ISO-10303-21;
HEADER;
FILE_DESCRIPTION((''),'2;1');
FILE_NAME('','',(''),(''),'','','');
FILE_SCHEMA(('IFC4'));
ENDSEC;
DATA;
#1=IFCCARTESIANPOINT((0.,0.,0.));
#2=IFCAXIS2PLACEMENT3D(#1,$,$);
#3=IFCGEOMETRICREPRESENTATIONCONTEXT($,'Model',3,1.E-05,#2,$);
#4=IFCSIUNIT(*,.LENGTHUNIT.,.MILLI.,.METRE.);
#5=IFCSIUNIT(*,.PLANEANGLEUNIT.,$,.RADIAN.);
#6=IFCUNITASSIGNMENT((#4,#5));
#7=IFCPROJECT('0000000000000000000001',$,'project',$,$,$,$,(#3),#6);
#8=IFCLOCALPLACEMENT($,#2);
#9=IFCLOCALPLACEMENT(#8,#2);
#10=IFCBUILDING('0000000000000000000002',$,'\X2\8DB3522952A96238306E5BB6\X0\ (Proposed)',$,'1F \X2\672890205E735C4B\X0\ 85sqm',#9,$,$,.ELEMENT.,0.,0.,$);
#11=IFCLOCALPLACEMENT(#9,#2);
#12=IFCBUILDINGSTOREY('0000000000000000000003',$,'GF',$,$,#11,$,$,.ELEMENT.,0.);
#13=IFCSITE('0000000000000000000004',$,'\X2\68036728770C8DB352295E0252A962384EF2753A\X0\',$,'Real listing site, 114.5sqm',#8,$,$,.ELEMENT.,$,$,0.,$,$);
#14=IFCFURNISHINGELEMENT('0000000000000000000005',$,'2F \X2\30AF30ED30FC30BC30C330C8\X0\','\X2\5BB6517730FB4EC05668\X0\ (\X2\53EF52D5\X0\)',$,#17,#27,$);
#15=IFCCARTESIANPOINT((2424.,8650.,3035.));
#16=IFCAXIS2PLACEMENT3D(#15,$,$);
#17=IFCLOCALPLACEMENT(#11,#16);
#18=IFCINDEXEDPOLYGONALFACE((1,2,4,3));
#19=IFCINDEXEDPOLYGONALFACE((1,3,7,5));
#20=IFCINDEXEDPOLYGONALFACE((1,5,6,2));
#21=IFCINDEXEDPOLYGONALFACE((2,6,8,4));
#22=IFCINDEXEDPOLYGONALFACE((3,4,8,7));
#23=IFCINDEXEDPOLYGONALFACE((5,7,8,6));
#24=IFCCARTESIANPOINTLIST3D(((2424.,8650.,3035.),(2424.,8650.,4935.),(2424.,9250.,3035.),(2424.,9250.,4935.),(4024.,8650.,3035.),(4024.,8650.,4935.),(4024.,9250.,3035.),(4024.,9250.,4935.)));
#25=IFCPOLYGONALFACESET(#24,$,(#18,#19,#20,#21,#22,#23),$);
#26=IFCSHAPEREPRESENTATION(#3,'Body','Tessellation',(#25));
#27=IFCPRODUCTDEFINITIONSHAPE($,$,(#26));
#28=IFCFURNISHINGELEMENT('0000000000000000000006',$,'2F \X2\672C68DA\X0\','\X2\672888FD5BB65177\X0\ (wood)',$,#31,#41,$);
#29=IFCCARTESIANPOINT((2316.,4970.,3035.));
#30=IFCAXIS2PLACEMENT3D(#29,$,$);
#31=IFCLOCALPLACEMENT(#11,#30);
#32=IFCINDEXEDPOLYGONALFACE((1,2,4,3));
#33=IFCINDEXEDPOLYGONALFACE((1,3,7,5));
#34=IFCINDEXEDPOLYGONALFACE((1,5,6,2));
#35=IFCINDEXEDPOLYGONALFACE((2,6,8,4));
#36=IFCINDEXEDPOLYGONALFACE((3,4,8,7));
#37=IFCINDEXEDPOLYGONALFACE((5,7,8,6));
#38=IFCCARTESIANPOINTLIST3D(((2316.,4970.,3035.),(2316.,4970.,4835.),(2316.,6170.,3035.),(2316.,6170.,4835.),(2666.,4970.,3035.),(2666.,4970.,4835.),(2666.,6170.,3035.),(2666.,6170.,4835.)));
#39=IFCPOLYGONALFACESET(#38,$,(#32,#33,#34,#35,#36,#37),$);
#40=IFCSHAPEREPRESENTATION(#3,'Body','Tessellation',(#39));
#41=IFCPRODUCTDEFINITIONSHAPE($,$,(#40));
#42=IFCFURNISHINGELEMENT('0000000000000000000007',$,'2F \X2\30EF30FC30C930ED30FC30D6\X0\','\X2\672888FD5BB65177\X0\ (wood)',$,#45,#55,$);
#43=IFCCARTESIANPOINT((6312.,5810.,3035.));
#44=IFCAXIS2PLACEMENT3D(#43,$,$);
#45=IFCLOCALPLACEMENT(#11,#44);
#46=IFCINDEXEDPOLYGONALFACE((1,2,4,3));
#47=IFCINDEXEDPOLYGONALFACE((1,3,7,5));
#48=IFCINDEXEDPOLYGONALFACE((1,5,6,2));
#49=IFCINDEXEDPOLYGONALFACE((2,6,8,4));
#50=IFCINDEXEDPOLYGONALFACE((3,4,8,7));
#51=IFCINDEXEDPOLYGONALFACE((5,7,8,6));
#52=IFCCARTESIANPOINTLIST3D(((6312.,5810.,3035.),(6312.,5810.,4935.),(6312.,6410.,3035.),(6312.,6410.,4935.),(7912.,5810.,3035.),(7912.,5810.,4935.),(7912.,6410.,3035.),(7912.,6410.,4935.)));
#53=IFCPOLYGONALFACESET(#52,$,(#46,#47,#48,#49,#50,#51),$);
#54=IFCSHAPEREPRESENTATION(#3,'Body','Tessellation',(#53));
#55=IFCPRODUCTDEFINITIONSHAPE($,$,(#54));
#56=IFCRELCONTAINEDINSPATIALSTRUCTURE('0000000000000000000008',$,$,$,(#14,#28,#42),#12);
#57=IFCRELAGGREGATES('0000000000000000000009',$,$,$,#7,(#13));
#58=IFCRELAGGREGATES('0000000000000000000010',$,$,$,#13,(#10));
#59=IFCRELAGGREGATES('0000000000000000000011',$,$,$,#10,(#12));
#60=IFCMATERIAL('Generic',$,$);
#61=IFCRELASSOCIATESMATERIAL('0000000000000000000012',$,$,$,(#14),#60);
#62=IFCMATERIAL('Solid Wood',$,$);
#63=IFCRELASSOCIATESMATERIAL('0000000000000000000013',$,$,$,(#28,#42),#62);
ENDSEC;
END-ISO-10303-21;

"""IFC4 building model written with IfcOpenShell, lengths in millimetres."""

from ifc_helpers import new_model, si_unit, frame, frame_2d, origin, place, context, project, spatial, rectangle, extrude, material, element, save


model = new_model("IFC4")

# Units and contexts
model_context = context("Model", 3, precision=1e-05, world=origin())
ifc_project = project(units=[si_unit("LENGTHUNIT", "METRE", prefix="MILLI"), si_unit("PLANEANGLEUNIT", "RADIAN")], contexts=[model_context])

# Site, building, storey
site_placement = place(None, origin())
site = spatial("IfcSite", under=ifc_project, at=site_placement, Name="栃木県足利市助戸仲町", ObjectType="Real listing site, 114.5sqm", CompositionType="ELEMENT", RefElevation=0.0)
building_placement = place(site_placement, origin())
building = spatial("IfcBuilding", under=site, at=building_placement, Name="足利助戸の家 (Proposed)", ObjectType="1F 木造平屋 85sqm", CompositionType="ELEMENT", ElevationOfRefHeight=0.0, ElevationOfTerrain=0.0)
storey_placement = place(building_placement, origin())
storey = spatial("IfcBuildingStorey", under=building, at=storey_placement, Name="GF", CompositionType="ELEMENT", Elevation=0.0)

# Shared definitions
ifc_material_1 = material(Name="Solid Wood")

# Shared definitions
ifc_material_2 = material(Name="Generic")

# Furnishing elements
furnishing_1_placement = place(storey_placement, frame((2424.0, 8650.0, 3035.0)))
element("IfcFurnishingElement", 1, at=furnishing_1_placement, inside=storey, material=ifc_material_2, Name="2F クローゼット", Description="家具・什器 (可動)", context=model_context, shape_type="SweptSolid", body=[
    extrude(rectangle(XDim=1600.0, YDim=600.0, at=frame_2d((800.0, 300.0))), frame((2424.0, 8650.0, 3035.0)), (0.0, 0.0, 1.0), 1900.0),
])
furnishing_2_placement = place(storey_placement, frame((2316.0, 4970.0, 3035.0)))
element("IfcFurnishingElement", 2, at=furnishing_2_placement, inside=storey, material=ifc_material_1, Name="2F 本棚", Description="木製家具 (wood)", context=model_context, shape_type="SweptSolid", body=[
    extrude(rectangle(XDim=350.0, YDim=1200.0, at=frame_2d((175.0, 600.0))), frame((2316.0, 4970.0, 3035.0)), (0.0, 0.0, 1.0), 1800.0),
])
furnishing_3_placement = place(storey_placement, frame((6312.0, 5810.0, 3035.0)))
element("IfcFurnishingElement", 3, at=furnishing_3_placement, inside=storey, material=ifc_material_1, Name="2F ワードローブ", Description="木製家具 (wood)", context=model_context, shape_type="SweptSolid", body=[
    extrude(rectangle(XDim=1600.0, YDim=600.0, at=frame_2d((800.0, 300.0))), frame((6312.0, 5810.0, 3035.0)), (0.0, 0.0, 1.0), 1900.0),
])

save(model, "model.ifc")
